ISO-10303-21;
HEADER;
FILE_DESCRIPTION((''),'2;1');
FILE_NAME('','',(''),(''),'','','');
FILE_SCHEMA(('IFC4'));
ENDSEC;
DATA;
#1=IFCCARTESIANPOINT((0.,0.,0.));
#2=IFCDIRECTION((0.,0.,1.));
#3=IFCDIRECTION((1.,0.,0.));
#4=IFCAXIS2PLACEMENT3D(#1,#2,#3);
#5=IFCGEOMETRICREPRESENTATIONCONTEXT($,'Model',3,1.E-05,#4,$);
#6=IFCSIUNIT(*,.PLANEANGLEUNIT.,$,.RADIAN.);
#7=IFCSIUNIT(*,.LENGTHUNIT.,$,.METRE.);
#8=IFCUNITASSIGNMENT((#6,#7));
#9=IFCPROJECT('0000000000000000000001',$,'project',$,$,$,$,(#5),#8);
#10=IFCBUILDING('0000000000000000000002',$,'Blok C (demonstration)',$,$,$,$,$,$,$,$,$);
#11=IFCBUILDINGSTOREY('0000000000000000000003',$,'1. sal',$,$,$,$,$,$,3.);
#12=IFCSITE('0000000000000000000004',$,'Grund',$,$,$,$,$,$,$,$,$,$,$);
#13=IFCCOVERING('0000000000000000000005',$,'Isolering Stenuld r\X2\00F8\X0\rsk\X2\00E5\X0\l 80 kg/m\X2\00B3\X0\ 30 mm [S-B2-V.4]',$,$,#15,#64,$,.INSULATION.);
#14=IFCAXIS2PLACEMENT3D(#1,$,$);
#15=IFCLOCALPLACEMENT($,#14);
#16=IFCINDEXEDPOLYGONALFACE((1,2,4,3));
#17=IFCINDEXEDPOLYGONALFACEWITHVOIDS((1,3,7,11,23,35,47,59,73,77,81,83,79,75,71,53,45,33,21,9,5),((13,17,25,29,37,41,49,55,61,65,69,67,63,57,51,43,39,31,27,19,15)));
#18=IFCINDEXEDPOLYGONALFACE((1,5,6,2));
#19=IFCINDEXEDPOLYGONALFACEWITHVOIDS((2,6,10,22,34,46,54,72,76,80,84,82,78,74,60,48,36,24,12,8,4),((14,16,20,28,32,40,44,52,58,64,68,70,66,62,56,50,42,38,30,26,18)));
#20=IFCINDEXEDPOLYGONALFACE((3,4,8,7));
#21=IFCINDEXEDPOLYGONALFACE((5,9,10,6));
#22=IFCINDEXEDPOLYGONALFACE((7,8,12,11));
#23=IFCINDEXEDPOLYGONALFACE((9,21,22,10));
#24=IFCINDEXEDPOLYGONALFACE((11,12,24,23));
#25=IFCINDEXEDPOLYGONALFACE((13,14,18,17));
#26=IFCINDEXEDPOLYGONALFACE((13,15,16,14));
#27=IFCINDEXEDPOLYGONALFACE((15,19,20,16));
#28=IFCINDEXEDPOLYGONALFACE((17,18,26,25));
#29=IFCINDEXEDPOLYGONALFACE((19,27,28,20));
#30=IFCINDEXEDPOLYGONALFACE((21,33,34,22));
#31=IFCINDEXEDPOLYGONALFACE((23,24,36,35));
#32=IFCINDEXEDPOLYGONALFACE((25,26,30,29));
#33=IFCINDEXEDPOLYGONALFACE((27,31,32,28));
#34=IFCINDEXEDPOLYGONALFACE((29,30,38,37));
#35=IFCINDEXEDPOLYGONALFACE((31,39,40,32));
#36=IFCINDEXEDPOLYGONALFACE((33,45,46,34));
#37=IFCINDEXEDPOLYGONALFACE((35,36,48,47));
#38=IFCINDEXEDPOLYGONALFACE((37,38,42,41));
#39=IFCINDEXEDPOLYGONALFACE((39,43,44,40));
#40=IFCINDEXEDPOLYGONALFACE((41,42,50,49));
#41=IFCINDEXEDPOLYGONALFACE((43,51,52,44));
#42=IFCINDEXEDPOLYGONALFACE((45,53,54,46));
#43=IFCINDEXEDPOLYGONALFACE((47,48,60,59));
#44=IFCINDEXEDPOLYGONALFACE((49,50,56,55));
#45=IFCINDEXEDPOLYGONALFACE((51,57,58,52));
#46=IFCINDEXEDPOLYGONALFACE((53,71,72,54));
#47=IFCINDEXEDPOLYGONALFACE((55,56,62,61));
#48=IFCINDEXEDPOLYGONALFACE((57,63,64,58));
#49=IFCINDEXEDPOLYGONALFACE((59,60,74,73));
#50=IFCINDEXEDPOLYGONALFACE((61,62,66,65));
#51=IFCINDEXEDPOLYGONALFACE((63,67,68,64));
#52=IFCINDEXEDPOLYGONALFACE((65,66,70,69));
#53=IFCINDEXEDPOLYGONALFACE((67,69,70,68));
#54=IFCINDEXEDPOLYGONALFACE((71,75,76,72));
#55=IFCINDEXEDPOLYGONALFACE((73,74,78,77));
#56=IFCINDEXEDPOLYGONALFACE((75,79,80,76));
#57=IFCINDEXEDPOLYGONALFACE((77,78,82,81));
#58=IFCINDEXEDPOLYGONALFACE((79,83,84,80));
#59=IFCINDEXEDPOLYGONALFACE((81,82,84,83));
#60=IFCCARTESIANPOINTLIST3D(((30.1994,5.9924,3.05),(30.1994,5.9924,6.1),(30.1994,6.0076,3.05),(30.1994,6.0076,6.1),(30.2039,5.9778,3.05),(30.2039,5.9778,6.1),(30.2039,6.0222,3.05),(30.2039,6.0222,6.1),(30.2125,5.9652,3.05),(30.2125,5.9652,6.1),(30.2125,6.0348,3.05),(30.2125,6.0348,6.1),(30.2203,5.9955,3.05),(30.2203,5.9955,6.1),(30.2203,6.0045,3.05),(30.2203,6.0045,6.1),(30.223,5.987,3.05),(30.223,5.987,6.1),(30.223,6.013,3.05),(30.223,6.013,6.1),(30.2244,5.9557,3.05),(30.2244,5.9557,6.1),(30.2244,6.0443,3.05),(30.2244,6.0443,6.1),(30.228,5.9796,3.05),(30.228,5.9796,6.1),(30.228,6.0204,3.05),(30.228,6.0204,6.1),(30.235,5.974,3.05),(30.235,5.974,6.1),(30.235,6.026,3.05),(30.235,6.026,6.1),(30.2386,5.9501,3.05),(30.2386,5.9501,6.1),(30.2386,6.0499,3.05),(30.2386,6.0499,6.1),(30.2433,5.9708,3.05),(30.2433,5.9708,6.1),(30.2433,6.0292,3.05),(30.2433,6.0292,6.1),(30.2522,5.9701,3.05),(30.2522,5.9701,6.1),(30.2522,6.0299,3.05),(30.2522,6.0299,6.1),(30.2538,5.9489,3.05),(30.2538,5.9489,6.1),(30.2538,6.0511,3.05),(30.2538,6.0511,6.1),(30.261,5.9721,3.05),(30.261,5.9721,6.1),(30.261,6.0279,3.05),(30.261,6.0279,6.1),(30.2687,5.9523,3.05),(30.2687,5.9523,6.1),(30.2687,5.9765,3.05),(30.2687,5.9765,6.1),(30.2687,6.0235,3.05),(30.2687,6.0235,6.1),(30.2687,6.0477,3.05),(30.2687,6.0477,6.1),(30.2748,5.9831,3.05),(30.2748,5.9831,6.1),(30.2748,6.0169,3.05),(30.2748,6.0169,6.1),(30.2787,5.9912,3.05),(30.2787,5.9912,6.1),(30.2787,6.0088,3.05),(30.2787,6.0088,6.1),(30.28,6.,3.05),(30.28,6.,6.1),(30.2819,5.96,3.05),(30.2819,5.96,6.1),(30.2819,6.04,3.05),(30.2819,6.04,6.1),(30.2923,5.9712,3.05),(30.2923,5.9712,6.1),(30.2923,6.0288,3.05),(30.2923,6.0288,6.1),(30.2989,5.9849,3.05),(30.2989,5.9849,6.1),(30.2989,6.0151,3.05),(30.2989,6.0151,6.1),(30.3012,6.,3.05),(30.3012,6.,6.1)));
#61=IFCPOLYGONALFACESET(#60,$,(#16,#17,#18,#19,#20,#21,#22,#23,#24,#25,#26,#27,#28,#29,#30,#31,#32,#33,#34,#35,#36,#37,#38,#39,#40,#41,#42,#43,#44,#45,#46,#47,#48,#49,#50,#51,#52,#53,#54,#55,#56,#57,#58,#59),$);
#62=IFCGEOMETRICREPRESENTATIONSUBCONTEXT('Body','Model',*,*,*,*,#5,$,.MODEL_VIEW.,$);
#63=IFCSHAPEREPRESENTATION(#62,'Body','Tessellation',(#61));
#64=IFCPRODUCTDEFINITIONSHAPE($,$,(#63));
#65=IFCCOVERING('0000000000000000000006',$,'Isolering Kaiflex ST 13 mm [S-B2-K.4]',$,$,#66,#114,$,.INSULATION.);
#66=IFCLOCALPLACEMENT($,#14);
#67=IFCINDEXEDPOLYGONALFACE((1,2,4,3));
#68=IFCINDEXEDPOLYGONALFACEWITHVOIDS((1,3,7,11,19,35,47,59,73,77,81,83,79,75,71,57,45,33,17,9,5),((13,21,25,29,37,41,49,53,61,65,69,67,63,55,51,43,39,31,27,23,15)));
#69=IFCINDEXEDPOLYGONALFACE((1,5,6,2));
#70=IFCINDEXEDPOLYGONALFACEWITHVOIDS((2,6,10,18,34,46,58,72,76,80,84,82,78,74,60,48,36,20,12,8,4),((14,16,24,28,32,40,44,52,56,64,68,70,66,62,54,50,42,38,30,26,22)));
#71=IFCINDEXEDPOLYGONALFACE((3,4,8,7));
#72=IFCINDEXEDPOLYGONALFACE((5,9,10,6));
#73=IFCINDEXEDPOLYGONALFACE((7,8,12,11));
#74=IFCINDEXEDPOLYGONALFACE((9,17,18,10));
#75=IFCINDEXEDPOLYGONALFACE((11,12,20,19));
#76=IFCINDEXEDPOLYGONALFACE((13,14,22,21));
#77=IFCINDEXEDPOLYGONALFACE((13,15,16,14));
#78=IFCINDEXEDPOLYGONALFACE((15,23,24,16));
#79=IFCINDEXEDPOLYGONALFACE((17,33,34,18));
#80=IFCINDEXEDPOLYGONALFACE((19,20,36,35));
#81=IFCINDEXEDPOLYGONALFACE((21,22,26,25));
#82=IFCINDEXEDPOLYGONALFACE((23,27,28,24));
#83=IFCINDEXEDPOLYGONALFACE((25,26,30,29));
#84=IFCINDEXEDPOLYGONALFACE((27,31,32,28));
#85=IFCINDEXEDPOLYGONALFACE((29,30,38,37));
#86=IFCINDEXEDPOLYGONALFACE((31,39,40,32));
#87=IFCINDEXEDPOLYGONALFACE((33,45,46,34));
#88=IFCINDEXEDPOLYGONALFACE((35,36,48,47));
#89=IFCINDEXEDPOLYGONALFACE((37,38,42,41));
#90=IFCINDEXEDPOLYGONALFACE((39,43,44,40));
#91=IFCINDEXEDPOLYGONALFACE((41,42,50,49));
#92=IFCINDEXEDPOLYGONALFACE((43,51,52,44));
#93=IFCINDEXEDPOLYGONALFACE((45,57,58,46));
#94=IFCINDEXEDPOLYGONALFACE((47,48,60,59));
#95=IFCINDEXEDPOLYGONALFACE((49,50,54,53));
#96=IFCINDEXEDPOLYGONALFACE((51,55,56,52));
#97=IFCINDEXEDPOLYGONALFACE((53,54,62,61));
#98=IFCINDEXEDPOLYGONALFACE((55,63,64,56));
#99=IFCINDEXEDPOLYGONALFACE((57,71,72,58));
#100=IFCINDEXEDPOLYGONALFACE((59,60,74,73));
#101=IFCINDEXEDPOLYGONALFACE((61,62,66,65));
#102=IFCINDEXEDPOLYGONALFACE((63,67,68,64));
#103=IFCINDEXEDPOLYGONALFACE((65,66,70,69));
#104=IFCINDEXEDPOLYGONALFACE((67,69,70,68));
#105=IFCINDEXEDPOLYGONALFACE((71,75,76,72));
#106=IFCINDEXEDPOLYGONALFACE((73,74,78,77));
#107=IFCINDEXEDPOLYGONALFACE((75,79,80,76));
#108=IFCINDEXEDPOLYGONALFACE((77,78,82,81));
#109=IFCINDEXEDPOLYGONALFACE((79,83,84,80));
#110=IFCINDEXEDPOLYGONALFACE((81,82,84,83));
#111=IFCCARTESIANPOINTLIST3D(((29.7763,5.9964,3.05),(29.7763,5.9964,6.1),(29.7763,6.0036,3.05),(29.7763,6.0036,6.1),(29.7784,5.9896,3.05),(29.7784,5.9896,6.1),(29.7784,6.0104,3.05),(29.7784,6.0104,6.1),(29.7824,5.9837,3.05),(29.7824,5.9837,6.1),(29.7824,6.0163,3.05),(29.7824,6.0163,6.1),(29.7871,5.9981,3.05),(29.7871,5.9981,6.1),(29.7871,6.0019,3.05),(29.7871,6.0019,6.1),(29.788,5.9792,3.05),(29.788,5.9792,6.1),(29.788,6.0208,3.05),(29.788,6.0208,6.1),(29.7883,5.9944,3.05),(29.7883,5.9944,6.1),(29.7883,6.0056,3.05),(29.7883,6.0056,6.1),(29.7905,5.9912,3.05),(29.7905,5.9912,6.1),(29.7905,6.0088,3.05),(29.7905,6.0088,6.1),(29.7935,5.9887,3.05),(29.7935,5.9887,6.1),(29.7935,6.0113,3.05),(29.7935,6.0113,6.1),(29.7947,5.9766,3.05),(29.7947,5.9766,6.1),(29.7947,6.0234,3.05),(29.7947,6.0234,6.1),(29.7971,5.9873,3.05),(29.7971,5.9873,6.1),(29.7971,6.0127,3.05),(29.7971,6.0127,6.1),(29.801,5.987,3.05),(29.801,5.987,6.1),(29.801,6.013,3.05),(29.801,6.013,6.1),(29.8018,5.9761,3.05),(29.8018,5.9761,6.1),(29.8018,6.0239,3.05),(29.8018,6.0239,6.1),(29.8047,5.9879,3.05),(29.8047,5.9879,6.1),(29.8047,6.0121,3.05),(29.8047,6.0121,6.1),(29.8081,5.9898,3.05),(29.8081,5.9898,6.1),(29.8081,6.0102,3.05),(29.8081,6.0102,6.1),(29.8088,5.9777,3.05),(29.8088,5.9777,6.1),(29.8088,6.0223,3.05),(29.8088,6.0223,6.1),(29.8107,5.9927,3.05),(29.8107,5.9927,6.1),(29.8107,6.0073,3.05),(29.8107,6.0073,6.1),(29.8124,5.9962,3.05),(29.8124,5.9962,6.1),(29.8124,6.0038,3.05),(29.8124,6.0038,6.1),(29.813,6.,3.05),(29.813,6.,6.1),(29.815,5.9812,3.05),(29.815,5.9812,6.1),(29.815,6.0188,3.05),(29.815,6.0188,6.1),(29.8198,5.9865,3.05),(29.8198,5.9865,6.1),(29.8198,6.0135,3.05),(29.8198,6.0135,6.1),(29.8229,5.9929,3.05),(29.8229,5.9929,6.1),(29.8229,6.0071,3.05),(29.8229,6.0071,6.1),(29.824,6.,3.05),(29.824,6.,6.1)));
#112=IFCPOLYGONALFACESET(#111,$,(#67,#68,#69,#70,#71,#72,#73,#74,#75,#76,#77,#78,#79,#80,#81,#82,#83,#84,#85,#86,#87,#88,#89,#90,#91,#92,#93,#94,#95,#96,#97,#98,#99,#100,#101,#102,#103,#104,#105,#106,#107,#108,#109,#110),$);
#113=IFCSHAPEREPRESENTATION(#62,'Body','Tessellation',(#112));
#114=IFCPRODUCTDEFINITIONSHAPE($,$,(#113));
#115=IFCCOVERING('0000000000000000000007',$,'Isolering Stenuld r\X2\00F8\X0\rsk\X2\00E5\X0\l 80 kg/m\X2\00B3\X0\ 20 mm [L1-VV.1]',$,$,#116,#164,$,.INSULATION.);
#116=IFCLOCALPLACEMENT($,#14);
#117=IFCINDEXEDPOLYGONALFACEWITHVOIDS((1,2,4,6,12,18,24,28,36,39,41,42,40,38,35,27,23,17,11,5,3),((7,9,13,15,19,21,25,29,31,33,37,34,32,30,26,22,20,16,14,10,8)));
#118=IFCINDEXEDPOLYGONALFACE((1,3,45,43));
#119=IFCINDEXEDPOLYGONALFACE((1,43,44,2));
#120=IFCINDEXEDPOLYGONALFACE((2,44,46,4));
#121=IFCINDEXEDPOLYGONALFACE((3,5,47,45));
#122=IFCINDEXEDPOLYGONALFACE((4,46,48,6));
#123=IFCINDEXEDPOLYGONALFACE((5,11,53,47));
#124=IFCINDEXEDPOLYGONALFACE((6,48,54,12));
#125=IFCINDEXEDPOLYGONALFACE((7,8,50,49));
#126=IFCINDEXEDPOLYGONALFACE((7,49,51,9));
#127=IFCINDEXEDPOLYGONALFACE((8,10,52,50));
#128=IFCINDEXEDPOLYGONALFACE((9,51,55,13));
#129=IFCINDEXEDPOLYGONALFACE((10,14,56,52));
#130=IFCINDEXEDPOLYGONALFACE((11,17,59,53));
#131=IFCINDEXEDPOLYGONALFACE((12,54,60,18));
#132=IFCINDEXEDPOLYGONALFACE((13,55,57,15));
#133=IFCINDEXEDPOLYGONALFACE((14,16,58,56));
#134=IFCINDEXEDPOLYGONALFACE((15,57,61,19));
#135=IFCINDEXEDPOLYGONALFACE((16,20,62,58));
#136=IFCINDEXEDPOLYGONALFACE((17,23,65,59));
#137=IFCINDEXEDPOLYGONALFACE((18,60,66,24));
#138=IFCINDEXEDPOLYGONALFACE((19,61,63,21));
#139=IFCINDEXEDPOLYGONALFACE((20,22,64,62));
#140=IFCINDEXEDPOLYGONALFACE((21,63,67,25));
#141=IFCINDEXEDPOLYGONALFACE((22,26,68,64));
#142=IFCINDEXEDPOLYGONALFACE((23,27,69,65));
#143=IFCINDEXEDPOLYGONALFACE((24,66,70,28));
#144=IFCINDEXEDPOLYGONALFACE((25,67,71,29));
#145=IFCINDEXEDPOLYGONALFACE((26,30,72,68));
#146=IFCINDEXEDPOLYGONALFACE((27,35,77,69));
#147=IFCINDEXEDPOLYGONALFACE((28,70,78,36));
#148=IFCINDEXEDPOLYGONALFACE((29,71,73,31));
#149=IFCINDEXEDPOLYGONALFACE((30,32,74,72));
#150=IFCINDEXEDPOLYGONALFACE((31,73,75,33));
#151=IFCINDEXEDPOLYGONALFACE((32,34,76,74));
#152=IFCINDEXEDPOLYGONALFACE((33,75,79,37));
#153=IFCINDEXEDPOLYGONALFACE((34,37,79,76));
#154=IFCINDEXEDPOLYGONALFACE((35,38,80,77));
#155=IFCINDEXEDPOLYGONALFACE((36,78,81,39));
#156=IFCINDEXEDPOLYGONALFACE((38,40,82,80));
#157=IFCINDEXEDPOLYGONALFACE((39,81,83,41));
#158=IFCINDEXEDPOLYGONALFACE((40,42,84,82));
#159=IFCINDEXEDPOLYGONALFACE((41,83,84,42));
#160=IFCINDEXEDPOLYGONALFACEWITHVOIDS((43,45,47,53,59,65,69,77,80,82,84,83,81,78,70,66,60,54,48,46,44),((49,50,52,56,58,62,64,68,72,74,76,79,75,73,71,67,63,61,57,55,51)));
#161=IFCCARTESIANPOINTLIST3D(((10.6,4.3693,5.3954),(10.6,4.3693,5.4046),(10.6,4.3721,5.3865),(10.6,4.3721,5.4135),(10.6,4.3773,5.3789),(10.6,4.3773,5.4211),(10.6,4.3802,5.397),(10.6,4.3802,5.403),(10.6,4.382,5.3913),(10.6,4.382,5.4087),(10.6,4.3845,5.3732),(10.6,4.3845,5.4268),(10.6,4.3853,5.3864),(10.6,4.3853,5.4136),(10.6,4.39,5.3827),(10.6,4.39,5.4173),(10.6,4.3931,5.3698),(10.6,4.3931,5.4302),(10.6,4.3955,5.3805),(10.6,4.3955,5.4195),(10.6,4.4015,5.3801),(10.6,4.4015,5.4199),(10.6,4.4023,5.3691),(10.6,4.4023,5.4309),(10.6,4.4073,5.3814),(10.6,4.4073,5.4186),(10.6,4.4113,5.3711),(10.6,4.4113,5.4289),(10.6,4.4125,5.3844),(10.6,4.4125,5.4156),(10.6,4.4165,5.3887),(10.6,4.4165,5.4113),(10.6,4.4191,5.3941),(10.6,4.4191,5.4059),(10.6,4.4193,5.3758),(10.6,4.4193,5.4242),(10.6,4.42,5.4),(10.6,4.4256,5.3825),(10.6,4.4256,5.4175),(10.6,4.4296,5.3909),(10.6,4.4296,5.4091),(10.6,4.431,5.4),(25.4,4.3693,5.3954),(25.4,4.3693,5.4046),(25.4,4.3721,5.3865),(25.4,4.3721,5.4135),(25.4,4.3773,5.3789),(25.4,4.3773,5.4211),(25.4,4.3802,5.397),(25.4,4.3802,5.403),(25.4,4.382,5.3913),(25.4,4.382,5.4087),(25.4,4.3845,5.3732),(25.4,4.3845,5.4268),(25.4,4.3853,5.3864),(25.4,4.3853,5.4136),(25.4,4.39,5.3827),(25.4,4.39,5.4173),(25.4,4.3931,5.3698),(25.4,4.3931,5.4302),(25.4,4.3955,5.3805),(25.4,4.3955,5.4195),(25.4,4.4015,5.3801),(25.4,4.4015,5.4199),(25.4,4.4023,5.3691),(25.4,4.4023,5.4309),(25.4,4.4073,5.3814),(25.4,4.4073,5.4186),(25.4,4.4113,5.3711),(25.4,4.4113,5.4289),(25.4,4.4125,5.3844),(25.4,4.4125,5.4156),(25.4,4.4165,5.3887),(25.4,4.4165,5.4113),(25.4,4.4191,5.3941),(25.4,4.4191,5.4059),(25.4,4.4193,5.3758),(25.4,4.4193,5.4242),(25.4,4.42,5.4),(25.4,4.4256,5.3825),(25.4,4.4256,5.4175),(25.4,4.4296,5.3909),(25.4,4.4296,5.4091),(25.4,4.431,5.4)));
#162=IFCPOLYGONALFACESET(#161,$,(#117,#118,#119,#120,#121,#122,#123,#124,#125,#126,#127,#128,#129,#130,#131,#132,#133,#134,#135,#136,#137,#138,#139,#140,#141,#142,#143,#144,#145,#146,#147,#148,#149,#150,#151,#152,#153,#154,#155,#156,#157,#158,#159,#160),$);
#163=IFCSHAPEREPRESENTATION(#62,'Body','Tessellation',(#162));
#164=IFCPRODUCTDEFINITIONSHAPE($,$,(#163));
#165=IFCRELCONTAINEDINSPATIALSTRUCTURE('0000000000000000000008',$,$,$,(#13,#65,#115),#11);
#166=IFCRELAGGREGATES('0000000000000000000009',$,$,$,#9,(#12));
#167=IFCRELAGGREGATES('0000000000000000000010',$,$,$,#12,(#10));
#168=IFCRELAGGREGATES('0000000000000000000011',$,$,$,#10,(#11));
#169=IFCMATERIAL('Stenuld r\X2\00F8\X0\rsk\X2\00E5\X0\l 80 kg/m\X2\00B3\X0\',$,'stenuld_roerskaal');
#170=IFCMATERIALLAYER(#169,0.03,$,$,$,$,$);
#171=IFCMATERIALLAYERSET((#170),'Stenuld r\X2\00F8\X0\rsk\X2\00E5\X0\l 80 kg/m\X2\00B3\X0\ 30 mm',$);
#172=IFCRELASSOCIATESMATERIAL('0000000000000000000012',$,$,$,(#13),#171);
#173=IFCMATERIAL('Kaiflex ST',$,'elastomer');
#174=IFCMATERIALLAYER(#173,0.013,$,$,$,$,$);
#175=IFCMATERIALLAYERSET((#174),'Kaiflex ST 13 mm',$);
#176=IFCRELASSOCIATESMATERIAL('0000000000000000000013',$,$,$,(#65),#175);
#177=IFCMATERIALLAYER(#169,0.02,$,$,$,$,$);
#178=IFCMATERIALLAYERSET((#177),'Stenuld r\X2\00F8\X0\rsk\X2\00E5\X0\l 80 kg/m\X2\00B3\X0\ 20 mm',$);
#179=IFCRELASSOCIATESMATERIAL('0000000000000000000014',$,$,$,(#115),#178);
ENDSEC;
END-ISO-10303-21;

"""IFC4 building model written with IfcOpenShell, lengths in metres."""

from ifc_helpers import new_model, si_unit, frame, origin_with_axes, place, context, subcontext, project, spatial, hollow_circle, extrude, material, layer, layer_set, element, save


model = new_model("IFC4")

# Units and contexts
model_context = context("Model", 3, precision=1e-05, world=origin_with_axes())
body_context = subcontext(model_context, "Body", "Model", "MODEL_VIEW")
ifc_project = project(units=[si_unit("PLANEANGLEUNIT", "RADIAN"), si_unit("LENGTHUNIT", "METRE")], contexts=[model_context])

# Site, building, storey
site = spatial("IfcSite", under=ifc_project, Name="Grund")
building = spatial("IfcBuilding", under=site, Name="Blok C (demonstration)")
storey = spatial("IfcBuildingStorey", under=building, Name="1. sal", Elevation=3.0)

# Coverings
ifc_material_1 = material(Name="Stenuld rørskål 80 kg/m³", Category="stenuld_roerskaal")
ifc_material_2 = material(Name="Kaiflex ST", Category="elastomer")
ifc_layer_1 = layer(ifc_material_1, 0.03)
ifc_layer_set_1 = layer_set([ifc_layer_1], Name="Stenuld rørskål 80 kg/m³ 30 mm")
covering_1_placement = place(None, origin_with_axes())
element("IfcCovering", 1, at=covering_1_placement, inside=storey, material=ifc_layer_set_1, Name="Isolering Stenuld rørskål 80 kg/m³ 30 mm [S-B2-V.4]", PredefinedType="INSULATION", context=body_context, shape_type="SweptSolid", body=[
    extrude(hollow_circle(Radius=0.0512, WallThickness=0.0212), frame((30.25, 6.0, 3.05), z_axis=(0.0, 0.0, 1.0), x_axis=(1.0, 0.0, 0.0)), (0.0, 0.0, 1.0), 3.05),
])
ifc_layer_2 = layer(ifc_material_2, 0.013)
ifc_layer_set_2 = layer_set([ifc_layer_2], Name="Kaiflex ST 13 mm")
covering_2_placement = place(None, origin_with_axes())
element("IfcCovering", 2, at=covering_2_placement, inside=storey, material=ifc_layer_set_2, Name="Isolering Kaiflex ST 13 mm [S-B2-K.4]", PredefinedType="INSULATION", context=body_context, shape_type="SweptSolid", body=[
    extrude(hollow_circle(Radius=0.024, WallThickness=0.011), frame((29.8, 6.0, 3.05), z_axis=(0.0, 0.0, 1.0), x_axis=(1.0, 0.0, 0.0)), (0.0, 0.0, 1.0), 3.05),
])
ifc_layer_3 = layer(ifc_material_1, 0.02)
ifc_layer_set_3 = layer_set([ifc_layer_3], Name="Stenuld rørskål 80 kg/m³ 20 mm")
covering_3_placement = place(None, origin_with_axes())
element("IfcCovering", 3, at=covering_3_placement, inside=storey, material=ifc_layer_set_3, Name="Isolering Stenuld rørskål 80 kg/m³ 20 mm [L1-VV.1]", PredefinedType="INSULATION", context=body_context, shape_type="SweptSolid", body=[
    extrude(hollow_circle(Radius=0.031, WallThickness=0.011), frame((10.6, 4.4, 5.4), z_axis=(1.0, 0.0, 0.0), x_axis=(0.0, 1.0, 0.0)), (0.0, 0.0, 1.0), 14.8),
])

save(model, "model.ifc")
